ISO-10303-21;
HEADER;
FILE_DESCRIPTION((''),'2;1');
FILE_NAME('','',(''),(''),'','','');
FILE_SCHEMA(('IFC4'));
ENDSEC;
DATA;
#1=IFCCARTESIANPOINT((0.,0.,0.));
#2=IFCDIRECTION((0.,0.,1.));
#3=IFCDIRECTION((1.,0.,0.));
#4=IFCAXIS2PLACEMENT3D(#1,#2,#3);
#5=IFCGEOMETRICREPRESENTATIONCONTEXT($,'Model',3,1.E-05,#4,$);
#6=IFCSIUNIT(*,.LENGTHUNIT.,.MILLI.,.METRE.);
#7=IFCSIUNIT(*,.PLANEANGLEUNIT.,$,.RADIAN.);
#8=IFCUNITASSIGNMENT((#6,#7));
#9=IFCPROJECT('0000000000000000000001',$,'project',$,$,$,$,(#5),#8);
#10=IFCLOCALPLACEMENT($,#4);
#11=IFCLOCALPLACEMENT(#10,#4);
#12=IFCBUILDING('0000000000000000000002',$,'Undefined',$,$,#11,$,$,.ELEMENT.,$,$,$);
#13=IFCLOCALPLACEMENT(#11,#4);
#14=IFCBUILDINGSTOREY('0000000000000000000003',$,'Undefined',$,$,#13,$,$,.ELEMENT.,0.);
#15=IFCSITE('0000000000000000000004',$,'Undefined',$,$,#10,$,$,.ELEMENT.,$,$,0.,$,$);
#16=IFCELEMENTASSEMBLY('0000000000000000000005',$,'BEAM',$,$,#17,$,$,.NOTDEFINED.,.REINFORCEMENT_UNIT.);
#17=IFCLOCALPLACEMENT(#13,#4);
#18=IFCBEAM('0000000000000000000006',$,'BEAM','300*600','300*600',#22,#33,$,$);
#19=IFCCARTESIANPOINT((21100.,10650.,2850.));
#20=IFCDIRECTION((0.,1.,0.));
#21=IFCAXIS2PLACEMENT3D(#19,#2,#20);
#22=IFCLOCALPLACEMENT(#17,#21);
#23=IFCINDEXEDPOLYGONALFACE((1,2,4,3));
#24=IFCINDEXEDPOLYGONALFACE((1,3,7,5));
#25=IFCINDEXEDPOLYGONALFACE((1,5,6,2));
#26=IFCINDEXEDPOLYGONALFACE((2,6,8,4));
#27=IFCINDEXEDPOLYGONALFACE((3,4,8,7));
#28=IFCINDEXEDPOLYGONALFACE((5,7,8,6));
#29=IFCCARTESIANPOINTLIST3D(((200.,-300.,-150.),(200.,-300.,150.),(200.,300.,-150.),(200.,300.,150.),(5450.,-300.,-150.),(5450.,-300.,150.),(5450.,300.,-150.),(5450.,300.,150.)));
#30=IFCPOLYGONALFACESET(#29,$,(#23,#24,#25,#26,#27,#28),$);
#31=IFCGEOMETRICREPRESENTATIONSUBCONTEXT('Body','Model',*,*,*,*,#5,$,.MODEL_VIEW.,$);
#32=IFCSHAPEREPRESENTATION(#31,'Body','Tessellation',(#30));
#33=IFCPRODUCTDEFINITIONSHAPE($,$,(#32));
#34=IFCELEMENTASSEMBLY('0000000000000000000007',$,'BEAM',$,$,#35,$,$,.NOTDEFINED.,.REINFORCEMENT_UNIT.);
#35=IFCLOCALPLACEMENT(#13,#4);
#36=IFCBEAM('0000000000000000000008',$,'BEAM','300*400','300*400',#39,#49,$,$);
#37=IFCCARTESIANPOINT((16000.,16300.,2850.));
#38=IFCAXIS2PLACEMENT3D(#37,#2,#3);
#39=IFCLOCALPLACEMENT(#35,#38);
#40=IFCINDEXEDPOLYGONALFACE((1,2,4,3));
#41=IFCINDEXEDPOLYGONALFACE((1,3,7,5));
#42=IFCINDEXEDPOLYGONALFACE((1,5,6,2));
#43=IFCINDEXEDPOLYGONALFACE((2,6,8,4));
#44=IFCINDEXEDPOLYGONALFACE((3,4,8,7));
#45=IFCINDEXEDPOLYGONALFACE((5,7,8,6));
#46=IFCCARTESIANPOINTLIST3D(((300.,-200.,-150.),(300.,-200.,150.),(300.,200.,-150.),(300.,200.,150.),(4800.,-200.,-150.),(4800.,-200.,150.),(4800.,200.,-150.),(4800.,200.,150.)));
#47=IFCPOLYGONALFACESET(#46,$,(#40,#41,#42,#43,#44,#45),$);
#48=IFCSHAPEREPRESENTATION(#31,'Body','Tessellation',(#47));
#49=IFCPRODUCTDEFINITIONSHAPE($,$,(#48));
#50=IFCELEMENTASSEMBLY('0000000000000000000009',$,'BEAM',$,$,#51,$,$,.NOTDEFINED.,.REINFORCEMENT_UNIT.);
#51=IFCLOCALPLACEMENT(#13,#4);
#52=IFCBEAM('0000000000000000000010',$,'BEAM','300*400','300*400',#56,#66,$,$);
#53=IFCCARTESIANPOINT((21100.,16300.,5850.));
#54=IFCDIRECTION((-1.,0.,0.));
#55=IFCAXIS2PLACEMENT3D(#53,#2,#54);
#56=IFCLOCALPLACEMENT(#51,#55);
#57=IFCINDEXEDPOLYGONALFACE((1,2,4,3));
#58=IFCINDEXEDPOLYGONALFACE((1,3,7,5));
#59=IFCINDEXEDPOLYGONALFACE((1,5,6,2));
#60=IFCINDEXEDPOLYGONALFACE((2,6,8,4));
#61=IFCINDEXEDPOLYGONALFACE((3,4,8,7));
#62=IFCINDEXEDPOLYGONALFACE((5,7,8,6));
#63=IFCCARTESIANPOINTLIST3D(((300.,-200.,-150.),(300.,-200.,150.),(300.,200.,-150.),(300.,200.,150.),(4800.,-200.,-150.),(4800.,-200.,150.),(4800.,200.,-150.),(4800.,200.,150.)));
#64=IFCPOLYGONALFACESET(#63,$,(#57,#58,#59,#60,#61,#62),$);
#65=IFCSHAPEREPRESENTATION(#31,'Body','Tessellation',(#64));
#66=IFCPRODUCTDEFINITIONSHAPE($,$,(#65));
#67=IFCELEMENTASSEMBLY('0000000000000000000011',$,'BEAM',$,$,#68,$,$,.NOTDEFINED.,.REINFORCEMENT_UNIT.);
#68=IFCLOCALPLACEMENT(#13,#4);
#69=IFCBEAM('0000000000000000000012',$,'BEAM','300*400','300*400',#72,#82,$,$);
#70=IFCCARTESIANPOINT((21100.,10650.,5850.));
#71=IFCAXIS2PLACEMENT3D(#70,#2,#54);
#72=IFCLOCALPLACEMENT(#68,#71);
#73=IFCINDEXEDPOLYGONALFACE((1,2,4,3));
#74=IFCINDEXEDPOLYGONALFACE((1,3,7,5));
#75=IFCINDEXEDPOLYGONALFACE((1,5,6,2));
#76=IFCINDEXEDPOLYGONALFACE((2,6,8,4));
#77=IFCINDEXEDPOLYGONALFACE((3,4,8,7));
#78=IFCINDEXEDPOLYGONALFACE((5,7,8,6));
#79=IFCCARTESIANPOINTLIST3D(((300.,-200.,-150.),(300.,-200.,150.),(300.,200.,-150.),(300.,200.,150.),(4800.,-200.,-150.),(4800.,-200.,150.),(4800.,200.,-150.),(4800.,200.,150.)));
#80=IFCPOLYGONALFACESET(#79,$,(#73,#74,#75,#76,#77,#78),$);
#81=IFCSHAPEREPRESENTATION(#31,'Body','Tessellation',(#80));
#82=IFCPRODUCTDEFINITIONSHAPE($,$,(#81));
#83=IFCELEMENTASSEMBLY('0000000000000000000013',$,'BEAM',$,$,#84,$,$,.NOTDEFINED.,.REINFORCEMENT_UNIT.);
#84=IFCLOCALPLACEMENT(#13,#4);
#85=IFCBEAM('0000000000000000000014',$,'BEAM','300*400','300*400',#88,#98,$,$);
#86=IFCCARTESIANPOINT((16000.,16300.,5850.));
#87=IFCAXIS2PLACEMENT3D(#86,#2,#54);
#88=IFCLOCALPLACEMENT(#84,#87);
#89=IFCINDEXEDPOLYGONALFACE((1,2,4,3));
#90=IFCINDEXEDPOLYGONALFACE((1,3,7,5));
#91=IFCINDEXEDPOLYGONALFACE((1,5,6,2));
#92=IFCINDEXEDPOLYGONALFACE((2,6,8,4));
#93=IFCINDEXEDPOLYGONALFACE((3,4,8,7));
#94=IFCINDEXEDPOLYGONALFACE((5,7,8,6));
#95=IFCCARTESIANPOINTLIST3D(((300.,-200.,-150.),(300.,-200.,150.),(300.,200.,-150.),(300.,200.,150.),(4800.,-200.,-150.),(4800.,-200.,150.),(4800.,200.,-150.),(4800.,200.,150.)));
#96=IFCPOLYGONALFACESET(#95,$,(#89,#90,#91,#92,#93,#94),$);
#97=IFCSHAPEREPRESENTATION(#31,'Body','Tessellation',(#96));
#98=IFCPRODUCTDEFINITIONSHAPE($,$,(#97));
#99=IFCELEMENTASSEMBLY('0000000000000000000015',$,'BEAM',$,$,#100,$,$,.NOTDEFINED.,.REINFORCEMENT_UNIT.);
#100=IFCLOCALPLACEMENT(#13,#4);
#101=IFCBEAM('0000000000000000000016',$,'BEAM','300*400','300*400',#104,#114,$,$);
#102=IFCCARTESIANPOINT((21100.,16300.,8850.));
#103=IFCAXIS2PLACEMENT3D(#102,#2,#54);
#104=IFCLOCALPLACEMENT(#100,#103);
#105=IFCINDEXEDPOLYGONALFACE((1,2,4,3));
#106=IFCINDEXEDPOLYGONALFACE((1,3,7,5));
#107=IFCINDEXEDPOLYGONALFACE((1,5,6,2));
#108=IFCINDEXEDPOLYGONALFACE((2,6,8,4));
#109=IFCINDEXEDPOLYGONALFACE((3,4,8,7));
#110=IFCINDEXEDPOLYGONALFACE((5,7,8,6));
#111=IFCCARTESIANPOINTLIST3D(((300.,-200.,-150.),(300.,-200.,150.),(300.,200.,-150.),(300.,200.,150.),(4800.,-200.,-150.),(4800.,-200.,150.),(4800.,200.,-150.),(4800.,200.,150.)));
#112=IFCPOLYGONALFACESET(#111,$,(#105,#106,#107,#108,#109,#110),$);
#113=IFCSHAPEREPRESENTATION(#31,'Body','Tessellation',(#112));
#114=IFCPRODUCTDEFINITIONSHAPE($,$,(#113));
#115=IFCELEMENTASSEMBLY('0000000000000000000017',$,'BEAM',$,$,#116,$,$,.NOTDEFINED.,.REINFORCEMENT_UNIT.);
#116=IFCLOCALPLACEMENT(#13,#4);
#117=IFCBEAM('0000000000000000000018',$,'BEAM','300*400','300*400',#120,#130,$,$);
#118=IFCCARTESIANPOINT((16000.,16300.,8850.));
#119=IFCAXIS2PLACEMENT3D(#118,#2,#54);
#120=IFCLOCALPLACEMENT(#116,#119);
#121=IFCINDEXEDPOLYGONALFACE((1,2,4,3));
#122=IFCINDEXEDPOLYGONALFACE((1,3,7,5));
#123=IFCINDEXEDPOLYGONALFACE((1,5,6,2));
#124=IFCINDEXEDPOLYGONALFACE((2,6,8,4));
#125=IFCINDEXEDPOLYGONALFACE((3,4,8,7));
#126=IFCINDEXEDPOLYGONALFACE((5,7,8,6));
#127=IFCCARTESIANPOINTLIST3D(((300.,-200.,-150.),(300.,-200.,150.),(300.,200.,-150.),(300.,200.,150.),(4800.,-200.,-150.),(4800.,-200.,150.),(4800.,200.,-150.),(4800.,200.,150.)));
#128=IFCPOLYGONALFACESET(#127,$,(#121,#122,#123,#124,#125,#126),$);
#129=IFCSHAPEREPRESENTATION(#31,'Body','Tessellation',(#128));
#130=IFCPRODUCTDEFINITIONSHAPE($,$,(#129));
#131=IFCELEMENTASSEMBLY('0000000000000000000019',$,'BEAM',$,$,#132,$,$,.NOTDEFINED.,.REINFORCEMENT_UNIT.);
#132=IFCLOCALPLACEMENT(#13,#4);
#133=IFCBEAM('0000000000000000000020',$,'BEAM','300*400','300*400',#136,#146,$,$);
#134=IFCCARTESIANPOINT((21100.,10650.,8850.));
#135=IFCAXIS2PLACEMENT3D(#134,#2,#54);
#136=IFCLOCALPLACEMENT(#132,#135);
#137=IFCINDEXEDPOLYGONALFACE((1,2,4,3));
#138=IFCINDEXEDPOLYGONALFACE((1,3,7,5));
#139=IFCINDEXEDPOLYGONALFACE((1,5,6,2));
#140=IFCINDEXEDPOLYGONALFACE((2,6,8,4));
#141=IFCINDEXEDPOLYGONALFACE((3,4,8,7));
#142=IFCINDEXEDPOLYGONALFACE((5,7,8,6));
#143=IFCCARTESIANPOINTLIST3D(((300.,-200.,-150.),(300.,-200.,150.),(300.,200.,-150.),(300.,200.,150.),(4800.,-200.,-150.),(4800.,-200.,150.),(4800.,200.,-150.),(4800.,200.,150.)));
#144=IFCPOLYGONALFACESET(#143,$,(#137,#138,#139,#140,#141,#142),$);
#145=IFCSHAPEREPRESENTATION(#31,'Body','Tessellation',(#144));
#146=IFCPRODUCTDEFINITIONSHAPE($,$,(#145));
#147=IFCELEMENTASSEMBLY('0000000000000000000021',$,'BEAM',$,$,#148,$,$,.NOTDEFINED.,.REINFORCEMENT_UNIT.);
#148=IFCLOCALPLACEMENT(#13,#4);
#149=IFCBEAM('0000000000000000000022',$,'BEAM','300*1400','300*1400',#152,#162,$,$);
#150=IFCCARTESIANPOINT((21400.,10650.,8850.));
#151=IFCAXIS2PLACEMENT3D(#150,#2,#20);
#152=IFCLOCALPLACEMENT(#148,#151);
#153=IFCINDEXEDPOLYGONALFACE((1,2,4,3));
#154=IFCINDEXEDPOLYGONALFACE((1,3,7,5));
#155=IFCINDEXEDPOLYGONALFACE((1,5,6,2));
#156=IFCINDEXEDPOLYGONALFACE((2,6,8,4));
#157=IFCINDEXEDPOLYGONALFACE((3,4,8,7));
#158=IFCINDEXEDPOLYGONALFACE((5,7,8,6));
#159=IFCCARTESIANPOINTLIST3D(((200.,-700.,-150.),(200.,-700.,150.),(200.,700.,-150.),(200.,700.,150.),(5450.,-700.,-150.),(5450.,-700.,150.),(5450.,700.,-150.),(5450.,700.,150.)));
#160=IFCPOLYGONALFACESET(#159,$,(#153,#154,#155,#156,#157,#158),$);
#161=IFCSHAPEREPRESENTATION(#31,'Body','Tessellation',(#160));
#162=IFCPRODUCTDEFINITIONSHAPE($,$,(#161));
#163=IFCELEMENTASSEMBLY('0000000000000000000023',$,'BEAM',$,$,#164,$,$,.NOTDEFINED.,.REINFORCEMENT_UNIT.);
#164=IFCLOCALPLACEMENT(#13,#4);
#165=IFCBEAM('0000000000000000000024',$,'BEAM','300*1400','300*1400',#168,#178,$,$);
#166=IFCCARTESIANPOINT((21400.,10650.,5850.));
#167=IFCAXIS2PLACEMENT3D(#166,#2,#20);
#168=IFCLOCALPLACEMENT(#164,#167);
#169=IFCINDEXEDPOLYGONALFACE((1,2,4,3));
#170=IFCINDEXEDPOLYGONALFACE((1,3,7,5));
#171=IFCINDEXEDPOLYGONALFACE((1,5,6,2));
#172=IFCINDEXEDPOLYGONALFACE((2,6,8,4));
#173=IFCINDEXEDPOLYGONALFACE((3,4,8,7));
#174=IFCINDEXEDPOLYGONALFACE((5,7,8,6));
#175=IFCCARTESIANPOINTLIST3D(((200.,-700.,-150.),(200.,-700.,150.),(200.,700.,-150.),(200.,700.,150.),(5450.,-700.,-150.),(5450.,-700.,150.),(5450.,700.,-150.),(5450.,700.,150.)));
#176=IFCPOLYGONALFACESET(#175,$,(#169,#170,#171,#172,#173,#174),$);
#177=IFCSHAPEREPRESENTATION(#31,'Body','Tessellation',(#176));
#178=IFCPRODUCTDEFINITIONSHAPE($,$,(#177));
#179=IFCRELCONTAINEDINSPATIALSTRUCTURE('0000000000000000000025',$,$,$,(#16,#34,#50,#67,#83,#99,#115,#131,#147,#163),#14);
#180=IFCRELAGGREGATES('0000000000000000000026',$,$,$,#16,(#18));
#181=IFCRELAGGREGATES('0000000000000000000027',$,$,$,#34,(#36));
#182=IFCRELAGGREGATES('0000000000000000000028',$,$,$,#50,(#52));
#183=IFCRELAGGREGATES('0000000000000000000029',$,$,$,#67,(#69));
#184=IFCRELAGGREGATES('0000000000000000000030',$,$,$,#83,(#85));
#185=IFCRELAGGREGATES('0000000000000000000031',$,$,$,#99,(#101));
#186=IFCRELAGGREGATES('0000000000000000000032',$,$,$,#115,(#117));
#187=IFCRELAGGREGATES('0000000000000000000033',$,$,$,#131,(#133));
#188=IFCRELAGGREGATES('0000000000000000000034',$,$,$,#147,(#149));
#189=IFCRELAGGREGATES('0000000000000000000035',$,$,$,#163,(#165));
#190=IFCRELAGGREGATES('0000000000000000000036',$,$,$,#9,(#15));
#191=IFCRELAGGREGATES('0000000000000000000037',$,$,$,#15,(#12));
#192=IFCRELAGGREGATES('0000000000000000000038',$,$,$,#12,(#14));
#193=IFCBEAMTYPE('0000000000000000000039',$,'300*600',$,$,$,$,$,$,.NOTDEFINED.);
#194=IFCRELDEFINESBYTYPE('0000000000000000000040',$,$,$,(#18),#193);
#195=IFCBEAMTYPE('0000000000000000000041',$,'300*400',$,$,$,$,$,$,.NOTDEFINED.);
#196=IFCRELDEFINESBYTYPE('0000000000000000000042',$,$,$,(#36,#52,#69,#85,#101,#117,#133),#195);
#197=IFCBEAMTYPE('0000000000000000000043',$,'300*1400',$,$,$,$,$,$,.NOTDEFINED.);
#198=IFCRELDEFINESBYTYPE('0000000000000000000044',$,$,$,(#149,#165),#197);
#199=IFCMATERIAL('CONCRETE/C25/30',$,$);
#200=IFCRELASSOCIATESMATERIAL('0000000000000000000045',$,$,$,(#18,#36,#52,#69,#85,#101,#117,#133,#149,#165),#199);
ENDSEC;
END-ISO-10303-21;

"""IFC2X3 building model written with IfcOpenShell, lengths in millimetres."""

from ifc_helpers import new_model, si_unit, frame, origin_with_axes, origin_2d_with_axis, place, context, subcontext, project, spatial, rectangle, extrude, material, type_object, element, aggregate, save


model = new_model("IFC2X3")

# Units and contexts
model_context = context("Model", 3, precision=1e-05, world=origin_with_axes())
body_context = subcontext(model_context, "Body", "Model", "MODEL_VIEW")
ifc_project = project(units=[si_unit("LENGTHUNIT", "METRE", prefix="MILLI"), si_unit("PLANEANGLEUNIT", "RADIAN")], contexts=[model_context])

# Site, building, storey
site_placement = place(None, origin_with_axes())
site = spatial("IfcSite", under=ifc_project, at=site_placement, Name="Undefined", CompositionType="ELEMENT", RefElevation=0.0)
building_placement = place(site_placement, origin_with_axes())
building = spatial("IfcBuilding", under=site, at=building_placement, Name="Undefined", CompositionType="ELEMENT")
storey_placement = place(building_placement, origin_with_axes())
storey = spatial("IfcBuildingStorey", under=building, at=storey_placement, Name="Undefined", CompositionType="ELEMENT", Elevation=0.0)

# Shared definitions
ifc_material = material(Name="CONCRETE/C25/30")

# Element assemblies, beams
assembly_1_placement = place(storey_placement, origin_with_axes())
assembly_1 = element("IfcElementAssembly", 1, at=assembly_1_placement, inside=storey, Name="BEAM", AssemblyPlace="NOTDEFINED", PredefinedType="REINFORCEMENT_UNIT")
beam_type_1 = type_object("IfcBeamType", Name="300*600", PredefinedType="NOTDEFINED")
beam_1_placement = place(assembly_1_placement, frame((21100.0, 10650.0, 2850.0), z_axis=(0.0, 0.0, 1.0), x_axis=(0.0, 1.0, 0.0)))
beam_1 = element("IfcBeam", 2, at=beam_1_placement, type_object=beam_type_1, material=ifc_material, Name="BEAM", Description="300*600", ObjectType="300*600", context=body_context, shape_type="SweptSolid", body=[
    extrude(rectangle(XDim=600.0, YDim=300.0, at=origin_2d_with_axis()), frame((5450.0, 0.0, 0.0), z_axis=(-1.0, 0.0, 0.0), x_axis=(0.0, -1.0, 0.0)), (0.0, 0.0, 1.0), 5250.0),
])
aggregate(assembly_1, [beam_1])
assembly_2_placement = place(storey_placement, origin_with_axes())
assembly_2 = element("IfcElementAssembly", 3, at=assembly_2_placement, inside=storey, Name="BEAM", AssemblyPlace="NOTDEFINED", PredefinedType="REINFORCEMENT_UNIT")
beam_type_2 = type_object("IfcBeamType", Name="300*400", PredefinedType="NOTDEFINED")
beam_2_placement = place(assembly_2_placement, frame((16000.0, 16300.0, 2850.0), z_axis=(0.0, 0.0, 1.0), x_axis=(1.0, 0.0, 0.0)))
beam_2 = element("IfcBeam", 4, at=beam_2_placement, type_object=beam_type_2, material=ifc_material, Name="BEAM", Description="300*400", ObjectType="300*400", context=body_context, shape_type="SweptSolid", body=[
    extrude(rectangle(XDim=400.0, YDim=300.0, at=origin_2d_with_axis()), frame((4800.0, 0.0, 0.0), z_axis=(-1.0, 0.0, 0.0), x_axis=(0.0, -1.0, 0.0)), (0.0, 0.0, 1.0), 4500.0),
])
aggregate(assembly_2, [beam_2])
assembly_3_placement = place(storey_placement, origin_with_axes())
assembly_3 = element("IfcElementAssembly", 5, at=assembly_3_placement, inside=storey, Name="BEAM", AssemblyPlace="NOTDEFINED", PredefinedType="REINFORCEMENT_UNIT")
beam_3_placement = place(assembly_3_placement, frame((21100.0, 16300.0, 5850.0), z_axis=(0.0, 0.0, 1.0), x_axis=(-1.0, 0.0, 0.0)))
beam_3 = element("IfcBeam", 6, at=beam_3_placement, type_object=beam_type_2, material=ifc_material, Name="BEAM", Description="300*400", ObjectType="300*400", context=body_context, shape_type="SweptSolid", body=[
    extrude(rectangle(XDim=400.0, YDim=300.0, at=origin_2d_with_axis()), frame((4800.0, 0.0, 0.0), z_axis=(-1.0, 0.0, 0.0), x_axis=(0.0, -1.0, 0.0)), (0.0, 0.0, 1.0), 4500.0),
])
aggregate(assembly_3, [beam_3])
assembly_4_placement = place(storey_placement, origin_with_axes())
assembly_4 = element("IfcElementAssembly", 7, at=assembly_4_placement, inside=storey, Name="BEAM", AssemblyPlace="NOTDEFINED", PredefinedType="REINFORCEMENT_UNIT")
beam_4_placement = place(assembly_4_placement, frame((21100.0, 10650.0, 5850.0), z_axis=(0.0, 0.0, 1.0), x_axis=(-1.0, 0.0, 0.0)))
beam_4 = element("IfcBeam", 8, at=beam_4_placement, type_object=beam_type_2, material=ifc_material, Name="BEAM", Description="300*400", ObjectType="300*400", context=body_context, shape_type="SweptSolid", body=[
    extrude(rectangle(XDim=400.0, YDim=300.0, at=origin_2d_with_axis()), frame((4800.0, 0.0, 0.0), z_axis=(-1.0, 0.0, 0.0), x_axis=(0.0, -1.0, 0.0)), (0.0, 0.0, 1.0), 4500.0),
])
aggregate(assembly_4, [beam_4])
assembly_5_placement = place(storey_placement, origin_with_axes())
assembly_5 = element("IfcElementAssembly", 9, at=assembly_5_placement, inside=storey, Name="BEAM", AssemblyPlace="NOTDEFINED", PredefinedType="REINFORCEMENT_UNIT")
beam_5_placement = place(assembly_5_placement, frame((16000.0, 16300.0, 5850.0), z_axis=(0.0, 0.0, 1.0), x_axis=(-1.0, 0.0, 0.0)))
beam_5 = element("IfcBeam", 10, at=beam_5_placement, type_object=beam_type_2, material=ifc_material, Name="BEAM", Description="300*400", ObjectType="300*400", context=body_context, shape_type="SweptSolid", body=[
    extrude(rectangle(XDim=400.0, YDim=300.0, at=origin_2d_with_axis()), frame((4800.0, 0.0, 0.0), z_axis=(-1.0, 0.0, 0.0), x_axis=(0.0, -1.0, 0.0)), (0.0, 0.0, 1.0), 4500.0),
])
aggregate(assembly_5, [beam_5])
assembly_6_placement = place(storey_placement, origin_with_axes())
assembly_6 = element("IfcElementAssembly", 11, at=assembly_6_placement, inside=storey, Name="BEAM", AssemblyPlace="NOTDEFINED", PredefinedType="REINFORCEMENT_UNIT")
beam_6_placement = place(assembly_6_placement, frame((21100.0, 16300.0, 8850.0), z_axis=(0.0, 0.0, 1.0), x_axis=(-1.0, 0.0, 0.0)))
beam_6 = element("IfcBeam", 12, at=beam_6_placement, type_object=beam_type_2, material=ifc_material, Name="BEAM", Description="300*400", ObjectType="300*400", context=body_context, shape_type="SweptSolid", body=[
    extrude(rectangle(XDim=400.0, YDim=300.0, at=origin_2d_with_axis()), frame((4800.0, 0.0, 0.0), z_axis=(-1.0, 0.0, 0.0), x_axis=(0.0, -1.0, 0.0)), (0.0, 0.0, 1.0), 4500.0),
])
aggregate(assembly_6, [beam_6])
assembly_7_placement = place(storey_placement, origin_with_axes())
assembly_7 = element("IfcElementAssembly", 13, at=assembly_7_placement, inside=storey, Name="BEAM", AssemblyPlace="NOTDEFINED", PredefinedType="REINFORCEMENT_UNIT")
beam_7_placement = place(assembly_7_placement, frame((16000.0, 16300.0, 8850.0), z_axis=(0.0, 0.0, 1.0), x_axis=(-1.0, 0.0, 0.0)))
beam_7 = element("IfcBeam", 14, at=beam_7_placement, type_object=beam_type_2, material=ifc_material, Name="BEAM", Description="300*400", ObjectType="300*400", context=body_context, shape_type="SweptSolid", body=[
    extrude(rectangle(XDim=400.0, YDim=300.0, at=origin_2d_with_axis()), frame((4800.0, 0.0, 0.0), z_axis=(-1.0, 0.0, 0.0), x_axis=(0.0, -1.0, 0.0)), (0.0, 0.0, 1.0), 4500.0),
])
aggregate(assembly_7, [beam_7])
assembly_8_placement = place(storey_placement, origin_with_axes())
assembly_8 = element("IfcElementAssembly", 15, at=assembly_8_placement, inside=storey, Name="BEAM", AssemblyPlace="NOTDEFINED", PredefinedType="REINFORCEMENT_UNIT")
beam_8_placement = place(assembly_8_placement, frame((21100.0, 10650.0, 8850.0), z_axis=(0.0, 0.0, 1.0), x_axis=(-1.0, 0.0, 0.0)))
beam_8 = element("IfcBeam", 16, at=beam_8_placement, type_object=beam_type_2, material=ifc_material, Name="BEAM", Description="300*400", ObjectType="300*400", context=body_context, shape_type="SweptSolid", body=[
    extrude(rectangle(XDim=400.0, YDim=300.0, at=origin_2d_with_axis()), frame((4800.0, 0.0, 0.0), z_axis=(-1.0, 0.0, 0.0), x_axis=(0.0, -1.0, 0.0)), (0.0, 0.0, 1.0), 4500.0),
])
aggregate(assembly_8, [beam_8])
beam_type_3 = type_object("IfcBeamType", Name="300*1400", PredefinedType="NOTDEFINED")
assembly_9_placement = place(storey_placement, origin_with_axes())
assembly_9 = element("IfcElementAssembly", 17, at=assembly_9_placement, inside=storey, Name="BEAM", AssemblyPlace="NOTDEFINED", PredefinedType="REINFORCEMENT_UNIT")
beam_9_placement = place(assembly_9_placement, frame((21400.0, 10650.0, 8850.0), z_axis=(0.0, 0.0, 1.0), x_axis=(0.0, 1.0, 0.0)))
beam_9 = element("IfcBeam", 18, at=beam_9_placement, type_object=beam_type_3, material=ifc_material, Name="BEAM", Description="300*1400", ObjectType="300*1400", context=body_context, shape_type="SweptSolid", body=[
    extrude(rectangle(XDim=1400.0, YDim=300.0, at=origin_2d_with_axis()), frame((5450.0, 0.0, 0.0), z_axis=(-1.0, 0.0, 0.0), x_axis=(0.0, -1.0, 0.0)), (0.0, 0.0, 1.0), 5250.0),
])
aggregate(assembly_9, [beam_9])
assembly_10_placement = place(storey_placement, origin_with_axes())
assembly_10 = element("IfcElementAssembly", 19, at=assembly_10_placement, inside=storey, Name="BEAM", AssemblyPlace="NOTDEFINED", PredefinedType="REINFORCEMENT_UNIT")
beam_10_placement = place(assembly_10_placement, frame((21400.0, 10650.0, 5850.0), z_axis=(0.0, 0.0, 1.0), x_axis=(0.0, 1.0, 0.0)))
beam_10 = element("IfcBeam", 20, at=beam_10_placement, type_object=beam_type_3, material=ifc_material, Name="BEAM", Description="300*1400", ObjectType="300*1400", context=body_context, shape_type="SweptSolid", body=[
    extrude(rectangle(XDim=1400.0, YDim=300.0, at=origin_2d_with_axis()), frame((5450.0, 0.0, 0.0), z_axis=(-1.0, 0.0, 0.0), x_axis=(0.0, -1.0, 0.0)), (0.0, 0.0, 1.0), 5250.0),
])
aggregate(assembly_10, [beam_10])

save(model, "model.ifc")
